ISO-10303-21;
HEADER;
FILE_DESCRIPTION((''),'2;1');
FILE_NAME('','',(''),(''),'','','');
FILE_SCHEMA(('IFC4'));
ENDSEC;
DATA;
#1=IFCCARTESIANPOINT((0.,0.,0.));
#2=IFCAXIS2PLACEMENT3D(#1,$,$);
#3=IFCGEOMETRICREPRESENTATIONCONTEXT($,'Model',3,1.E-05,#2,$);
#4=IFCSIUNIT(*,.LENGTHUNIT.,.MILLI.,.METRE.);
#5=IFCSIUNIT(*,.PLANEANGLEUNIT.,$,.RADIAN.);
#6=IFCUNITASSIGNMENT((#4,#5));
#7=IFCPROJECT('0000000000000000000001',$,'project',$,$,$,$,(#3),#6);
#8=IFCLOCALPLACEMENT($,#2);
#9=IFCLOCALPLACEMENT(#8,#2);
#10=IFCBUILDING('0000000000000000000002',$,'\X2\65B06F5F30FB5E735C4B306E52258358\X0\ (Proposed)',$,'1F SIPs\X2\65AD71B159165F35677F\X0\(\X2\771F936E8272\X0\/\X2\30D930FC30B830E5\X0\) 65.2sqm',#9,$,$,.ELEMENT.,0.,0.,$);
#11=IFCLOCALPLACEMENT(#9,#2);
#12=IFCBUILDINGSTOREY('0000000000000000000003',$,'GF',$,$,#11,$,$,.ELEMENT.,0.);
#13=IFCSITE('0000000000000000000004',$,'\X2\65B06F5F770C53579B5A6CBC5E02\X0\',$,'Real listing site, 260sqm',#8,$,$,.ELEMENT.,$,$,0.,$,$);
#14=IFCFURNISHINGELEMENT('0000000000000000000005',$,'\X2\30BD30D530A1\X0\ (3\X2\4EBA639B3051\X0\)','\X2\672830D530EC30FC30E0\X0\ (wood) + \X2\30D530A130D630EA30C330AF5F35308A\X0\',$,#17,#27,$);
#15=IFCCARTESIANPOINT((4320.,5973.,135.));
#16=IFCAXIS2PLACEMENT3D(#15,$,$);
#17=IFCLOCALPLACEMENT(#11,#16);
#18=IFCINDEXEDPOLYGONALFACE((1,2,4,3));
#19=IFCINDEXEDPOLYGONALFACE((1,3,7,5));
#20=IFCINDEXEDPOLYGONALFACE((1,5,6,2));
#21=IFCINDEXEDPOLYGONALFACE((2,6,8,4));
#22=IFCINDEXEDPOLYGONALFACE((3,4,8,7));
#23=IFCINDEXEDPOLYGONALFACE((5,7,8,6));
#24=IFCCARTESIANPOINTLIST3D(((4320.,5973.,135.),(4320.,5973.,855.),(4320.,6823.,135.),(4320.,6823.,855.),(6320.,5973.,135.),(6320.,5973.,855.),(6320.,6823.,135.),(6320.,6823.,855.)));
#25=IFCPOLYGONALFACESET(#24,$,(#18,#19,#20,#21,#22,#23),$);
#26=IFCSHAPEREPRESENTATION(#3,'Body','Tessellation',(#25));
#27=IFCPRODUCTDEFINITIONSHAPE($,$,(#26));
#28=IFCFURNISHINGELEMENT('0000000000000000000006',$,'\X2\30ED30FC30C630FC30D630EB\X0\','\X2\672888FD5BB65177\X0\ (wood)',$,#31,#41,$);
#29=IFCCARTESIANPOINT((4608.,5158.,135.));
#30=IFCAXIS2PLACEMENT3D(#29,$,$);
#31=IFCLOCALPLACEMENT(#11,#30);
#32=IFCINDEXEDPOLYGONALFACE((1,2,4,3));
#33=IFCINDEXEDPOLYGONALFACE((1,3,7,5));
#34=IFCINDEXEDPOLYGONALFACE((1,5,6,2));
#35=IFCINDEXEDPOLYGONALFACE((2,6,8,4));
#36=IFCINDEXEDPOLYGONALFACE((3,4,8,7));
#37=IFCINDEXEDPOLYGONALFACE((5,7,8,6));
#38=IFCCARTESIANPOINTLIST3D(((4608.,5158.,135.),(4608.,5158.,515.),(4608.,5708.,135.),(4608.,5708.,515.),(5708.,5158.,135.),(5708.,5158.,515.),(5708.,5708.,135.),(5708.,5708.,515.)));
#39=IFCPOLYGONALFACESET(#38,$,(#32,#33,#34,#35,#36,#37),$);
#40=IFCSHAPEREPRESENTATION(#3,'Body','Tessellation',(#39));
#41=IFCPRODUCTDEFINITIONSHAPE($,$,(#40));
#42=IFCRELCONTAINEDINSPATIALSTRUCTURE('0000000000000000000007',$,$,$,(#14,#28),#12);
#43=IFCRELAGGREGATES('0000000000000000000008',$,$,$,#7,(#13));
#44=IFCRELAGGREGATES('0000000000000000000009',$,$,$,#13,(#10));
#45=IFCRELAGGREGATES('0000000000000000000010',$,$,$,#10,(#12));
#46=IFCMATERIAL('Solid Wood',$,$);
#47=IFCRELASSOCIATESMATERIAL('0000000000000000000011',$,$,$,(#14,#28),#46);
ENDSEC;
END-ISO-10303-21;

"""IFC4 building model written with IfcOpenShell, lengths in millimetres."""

from ifc_helpers import new_model, si_unit, frame, frame_2d, origin, place, context, project, spatial, rectangle, extrude, material, element, save


model = new_model("IFC4")

# Units and contexts
model_context = context("Model", 3, precision=1e-05, world=origin())
ifc_project = project(units=[si_unit("LENGTHUNIT", "METRE", prefix="MILLI"), si_unit("PLANEANGLEUNIT", "RADIAN")], contexts=[model_context])

# Site, building, storey
site_placement = place(None, origin())
site = spatial("IfcSite", under=ifc_project, at=site_placement, Name="新潟県南魚沼市", ObjectType="Real listing site, 260sqm", CompositionType="ELEMENT", RefElevation=0.0)
building_placement = place(site_placement, origin())
building = spatial("IfcBuilding", under=site, at=building_placement, Name="新潟・平屋の別荘 (Proposed)", ObjectType="1F SIPs断熱外張板(真鍮色/ベージュ) 65.2sqm", CompositionType="ELEMENT", ElevationOfRefHeight=0.0, ElevationOfTerrain=0.0)
storey_placement = place(building_placement, origin())
storey = spatial("IfcBuildingStorey", under=building, at=storey_placement, Name="GF", CompositionType="ELEMENT", Elevation=0.0)

# Shared definitions
ifc_material_1 = material(Name="Solid Wood")

# Furnishing elements
furnishing_1_placement = place(storey_placement, frame((4320.0, 5973.0, 135.0)))
element("IfcFurnishingElement", 1, at=furnishing_1_placement, inside=storey, material=ifc_material_1, Name="ソファ (3人掛け)", Description="木フレーム (wood) + ファブリック張り", context=model_context, shape_type="SweptSolid", body=[
    extrude(rectangle(XDim=2000.0, YDim=850.0, at=frame_2d((1000.0, 425.0))), frame((4320.0, 5973.0, 135.0)), (0.0, 0.0, 1.0), 720.0),
])
furnishing_2_placement = place(storey_placement, frame((4608.0, 5158.0, 135.0)))
element("IfcFurnishingElement", 2, at=furnishing_2_placement, inside=storey, material=ifc_material_1, Name="ローテーブル", Description="木製家具 (wood)", context=model_context, shape_type="SweptSolid", body=[
    extrude(rectangle(XDim=1100.0, YDim=550.0, at=frame_2d((550.0, 275.0))), frame((4608.0, 5158.0, 135.0)), (0.0, 0.0, 1.0), 380.0),
])

save(model, "model.ifc")
